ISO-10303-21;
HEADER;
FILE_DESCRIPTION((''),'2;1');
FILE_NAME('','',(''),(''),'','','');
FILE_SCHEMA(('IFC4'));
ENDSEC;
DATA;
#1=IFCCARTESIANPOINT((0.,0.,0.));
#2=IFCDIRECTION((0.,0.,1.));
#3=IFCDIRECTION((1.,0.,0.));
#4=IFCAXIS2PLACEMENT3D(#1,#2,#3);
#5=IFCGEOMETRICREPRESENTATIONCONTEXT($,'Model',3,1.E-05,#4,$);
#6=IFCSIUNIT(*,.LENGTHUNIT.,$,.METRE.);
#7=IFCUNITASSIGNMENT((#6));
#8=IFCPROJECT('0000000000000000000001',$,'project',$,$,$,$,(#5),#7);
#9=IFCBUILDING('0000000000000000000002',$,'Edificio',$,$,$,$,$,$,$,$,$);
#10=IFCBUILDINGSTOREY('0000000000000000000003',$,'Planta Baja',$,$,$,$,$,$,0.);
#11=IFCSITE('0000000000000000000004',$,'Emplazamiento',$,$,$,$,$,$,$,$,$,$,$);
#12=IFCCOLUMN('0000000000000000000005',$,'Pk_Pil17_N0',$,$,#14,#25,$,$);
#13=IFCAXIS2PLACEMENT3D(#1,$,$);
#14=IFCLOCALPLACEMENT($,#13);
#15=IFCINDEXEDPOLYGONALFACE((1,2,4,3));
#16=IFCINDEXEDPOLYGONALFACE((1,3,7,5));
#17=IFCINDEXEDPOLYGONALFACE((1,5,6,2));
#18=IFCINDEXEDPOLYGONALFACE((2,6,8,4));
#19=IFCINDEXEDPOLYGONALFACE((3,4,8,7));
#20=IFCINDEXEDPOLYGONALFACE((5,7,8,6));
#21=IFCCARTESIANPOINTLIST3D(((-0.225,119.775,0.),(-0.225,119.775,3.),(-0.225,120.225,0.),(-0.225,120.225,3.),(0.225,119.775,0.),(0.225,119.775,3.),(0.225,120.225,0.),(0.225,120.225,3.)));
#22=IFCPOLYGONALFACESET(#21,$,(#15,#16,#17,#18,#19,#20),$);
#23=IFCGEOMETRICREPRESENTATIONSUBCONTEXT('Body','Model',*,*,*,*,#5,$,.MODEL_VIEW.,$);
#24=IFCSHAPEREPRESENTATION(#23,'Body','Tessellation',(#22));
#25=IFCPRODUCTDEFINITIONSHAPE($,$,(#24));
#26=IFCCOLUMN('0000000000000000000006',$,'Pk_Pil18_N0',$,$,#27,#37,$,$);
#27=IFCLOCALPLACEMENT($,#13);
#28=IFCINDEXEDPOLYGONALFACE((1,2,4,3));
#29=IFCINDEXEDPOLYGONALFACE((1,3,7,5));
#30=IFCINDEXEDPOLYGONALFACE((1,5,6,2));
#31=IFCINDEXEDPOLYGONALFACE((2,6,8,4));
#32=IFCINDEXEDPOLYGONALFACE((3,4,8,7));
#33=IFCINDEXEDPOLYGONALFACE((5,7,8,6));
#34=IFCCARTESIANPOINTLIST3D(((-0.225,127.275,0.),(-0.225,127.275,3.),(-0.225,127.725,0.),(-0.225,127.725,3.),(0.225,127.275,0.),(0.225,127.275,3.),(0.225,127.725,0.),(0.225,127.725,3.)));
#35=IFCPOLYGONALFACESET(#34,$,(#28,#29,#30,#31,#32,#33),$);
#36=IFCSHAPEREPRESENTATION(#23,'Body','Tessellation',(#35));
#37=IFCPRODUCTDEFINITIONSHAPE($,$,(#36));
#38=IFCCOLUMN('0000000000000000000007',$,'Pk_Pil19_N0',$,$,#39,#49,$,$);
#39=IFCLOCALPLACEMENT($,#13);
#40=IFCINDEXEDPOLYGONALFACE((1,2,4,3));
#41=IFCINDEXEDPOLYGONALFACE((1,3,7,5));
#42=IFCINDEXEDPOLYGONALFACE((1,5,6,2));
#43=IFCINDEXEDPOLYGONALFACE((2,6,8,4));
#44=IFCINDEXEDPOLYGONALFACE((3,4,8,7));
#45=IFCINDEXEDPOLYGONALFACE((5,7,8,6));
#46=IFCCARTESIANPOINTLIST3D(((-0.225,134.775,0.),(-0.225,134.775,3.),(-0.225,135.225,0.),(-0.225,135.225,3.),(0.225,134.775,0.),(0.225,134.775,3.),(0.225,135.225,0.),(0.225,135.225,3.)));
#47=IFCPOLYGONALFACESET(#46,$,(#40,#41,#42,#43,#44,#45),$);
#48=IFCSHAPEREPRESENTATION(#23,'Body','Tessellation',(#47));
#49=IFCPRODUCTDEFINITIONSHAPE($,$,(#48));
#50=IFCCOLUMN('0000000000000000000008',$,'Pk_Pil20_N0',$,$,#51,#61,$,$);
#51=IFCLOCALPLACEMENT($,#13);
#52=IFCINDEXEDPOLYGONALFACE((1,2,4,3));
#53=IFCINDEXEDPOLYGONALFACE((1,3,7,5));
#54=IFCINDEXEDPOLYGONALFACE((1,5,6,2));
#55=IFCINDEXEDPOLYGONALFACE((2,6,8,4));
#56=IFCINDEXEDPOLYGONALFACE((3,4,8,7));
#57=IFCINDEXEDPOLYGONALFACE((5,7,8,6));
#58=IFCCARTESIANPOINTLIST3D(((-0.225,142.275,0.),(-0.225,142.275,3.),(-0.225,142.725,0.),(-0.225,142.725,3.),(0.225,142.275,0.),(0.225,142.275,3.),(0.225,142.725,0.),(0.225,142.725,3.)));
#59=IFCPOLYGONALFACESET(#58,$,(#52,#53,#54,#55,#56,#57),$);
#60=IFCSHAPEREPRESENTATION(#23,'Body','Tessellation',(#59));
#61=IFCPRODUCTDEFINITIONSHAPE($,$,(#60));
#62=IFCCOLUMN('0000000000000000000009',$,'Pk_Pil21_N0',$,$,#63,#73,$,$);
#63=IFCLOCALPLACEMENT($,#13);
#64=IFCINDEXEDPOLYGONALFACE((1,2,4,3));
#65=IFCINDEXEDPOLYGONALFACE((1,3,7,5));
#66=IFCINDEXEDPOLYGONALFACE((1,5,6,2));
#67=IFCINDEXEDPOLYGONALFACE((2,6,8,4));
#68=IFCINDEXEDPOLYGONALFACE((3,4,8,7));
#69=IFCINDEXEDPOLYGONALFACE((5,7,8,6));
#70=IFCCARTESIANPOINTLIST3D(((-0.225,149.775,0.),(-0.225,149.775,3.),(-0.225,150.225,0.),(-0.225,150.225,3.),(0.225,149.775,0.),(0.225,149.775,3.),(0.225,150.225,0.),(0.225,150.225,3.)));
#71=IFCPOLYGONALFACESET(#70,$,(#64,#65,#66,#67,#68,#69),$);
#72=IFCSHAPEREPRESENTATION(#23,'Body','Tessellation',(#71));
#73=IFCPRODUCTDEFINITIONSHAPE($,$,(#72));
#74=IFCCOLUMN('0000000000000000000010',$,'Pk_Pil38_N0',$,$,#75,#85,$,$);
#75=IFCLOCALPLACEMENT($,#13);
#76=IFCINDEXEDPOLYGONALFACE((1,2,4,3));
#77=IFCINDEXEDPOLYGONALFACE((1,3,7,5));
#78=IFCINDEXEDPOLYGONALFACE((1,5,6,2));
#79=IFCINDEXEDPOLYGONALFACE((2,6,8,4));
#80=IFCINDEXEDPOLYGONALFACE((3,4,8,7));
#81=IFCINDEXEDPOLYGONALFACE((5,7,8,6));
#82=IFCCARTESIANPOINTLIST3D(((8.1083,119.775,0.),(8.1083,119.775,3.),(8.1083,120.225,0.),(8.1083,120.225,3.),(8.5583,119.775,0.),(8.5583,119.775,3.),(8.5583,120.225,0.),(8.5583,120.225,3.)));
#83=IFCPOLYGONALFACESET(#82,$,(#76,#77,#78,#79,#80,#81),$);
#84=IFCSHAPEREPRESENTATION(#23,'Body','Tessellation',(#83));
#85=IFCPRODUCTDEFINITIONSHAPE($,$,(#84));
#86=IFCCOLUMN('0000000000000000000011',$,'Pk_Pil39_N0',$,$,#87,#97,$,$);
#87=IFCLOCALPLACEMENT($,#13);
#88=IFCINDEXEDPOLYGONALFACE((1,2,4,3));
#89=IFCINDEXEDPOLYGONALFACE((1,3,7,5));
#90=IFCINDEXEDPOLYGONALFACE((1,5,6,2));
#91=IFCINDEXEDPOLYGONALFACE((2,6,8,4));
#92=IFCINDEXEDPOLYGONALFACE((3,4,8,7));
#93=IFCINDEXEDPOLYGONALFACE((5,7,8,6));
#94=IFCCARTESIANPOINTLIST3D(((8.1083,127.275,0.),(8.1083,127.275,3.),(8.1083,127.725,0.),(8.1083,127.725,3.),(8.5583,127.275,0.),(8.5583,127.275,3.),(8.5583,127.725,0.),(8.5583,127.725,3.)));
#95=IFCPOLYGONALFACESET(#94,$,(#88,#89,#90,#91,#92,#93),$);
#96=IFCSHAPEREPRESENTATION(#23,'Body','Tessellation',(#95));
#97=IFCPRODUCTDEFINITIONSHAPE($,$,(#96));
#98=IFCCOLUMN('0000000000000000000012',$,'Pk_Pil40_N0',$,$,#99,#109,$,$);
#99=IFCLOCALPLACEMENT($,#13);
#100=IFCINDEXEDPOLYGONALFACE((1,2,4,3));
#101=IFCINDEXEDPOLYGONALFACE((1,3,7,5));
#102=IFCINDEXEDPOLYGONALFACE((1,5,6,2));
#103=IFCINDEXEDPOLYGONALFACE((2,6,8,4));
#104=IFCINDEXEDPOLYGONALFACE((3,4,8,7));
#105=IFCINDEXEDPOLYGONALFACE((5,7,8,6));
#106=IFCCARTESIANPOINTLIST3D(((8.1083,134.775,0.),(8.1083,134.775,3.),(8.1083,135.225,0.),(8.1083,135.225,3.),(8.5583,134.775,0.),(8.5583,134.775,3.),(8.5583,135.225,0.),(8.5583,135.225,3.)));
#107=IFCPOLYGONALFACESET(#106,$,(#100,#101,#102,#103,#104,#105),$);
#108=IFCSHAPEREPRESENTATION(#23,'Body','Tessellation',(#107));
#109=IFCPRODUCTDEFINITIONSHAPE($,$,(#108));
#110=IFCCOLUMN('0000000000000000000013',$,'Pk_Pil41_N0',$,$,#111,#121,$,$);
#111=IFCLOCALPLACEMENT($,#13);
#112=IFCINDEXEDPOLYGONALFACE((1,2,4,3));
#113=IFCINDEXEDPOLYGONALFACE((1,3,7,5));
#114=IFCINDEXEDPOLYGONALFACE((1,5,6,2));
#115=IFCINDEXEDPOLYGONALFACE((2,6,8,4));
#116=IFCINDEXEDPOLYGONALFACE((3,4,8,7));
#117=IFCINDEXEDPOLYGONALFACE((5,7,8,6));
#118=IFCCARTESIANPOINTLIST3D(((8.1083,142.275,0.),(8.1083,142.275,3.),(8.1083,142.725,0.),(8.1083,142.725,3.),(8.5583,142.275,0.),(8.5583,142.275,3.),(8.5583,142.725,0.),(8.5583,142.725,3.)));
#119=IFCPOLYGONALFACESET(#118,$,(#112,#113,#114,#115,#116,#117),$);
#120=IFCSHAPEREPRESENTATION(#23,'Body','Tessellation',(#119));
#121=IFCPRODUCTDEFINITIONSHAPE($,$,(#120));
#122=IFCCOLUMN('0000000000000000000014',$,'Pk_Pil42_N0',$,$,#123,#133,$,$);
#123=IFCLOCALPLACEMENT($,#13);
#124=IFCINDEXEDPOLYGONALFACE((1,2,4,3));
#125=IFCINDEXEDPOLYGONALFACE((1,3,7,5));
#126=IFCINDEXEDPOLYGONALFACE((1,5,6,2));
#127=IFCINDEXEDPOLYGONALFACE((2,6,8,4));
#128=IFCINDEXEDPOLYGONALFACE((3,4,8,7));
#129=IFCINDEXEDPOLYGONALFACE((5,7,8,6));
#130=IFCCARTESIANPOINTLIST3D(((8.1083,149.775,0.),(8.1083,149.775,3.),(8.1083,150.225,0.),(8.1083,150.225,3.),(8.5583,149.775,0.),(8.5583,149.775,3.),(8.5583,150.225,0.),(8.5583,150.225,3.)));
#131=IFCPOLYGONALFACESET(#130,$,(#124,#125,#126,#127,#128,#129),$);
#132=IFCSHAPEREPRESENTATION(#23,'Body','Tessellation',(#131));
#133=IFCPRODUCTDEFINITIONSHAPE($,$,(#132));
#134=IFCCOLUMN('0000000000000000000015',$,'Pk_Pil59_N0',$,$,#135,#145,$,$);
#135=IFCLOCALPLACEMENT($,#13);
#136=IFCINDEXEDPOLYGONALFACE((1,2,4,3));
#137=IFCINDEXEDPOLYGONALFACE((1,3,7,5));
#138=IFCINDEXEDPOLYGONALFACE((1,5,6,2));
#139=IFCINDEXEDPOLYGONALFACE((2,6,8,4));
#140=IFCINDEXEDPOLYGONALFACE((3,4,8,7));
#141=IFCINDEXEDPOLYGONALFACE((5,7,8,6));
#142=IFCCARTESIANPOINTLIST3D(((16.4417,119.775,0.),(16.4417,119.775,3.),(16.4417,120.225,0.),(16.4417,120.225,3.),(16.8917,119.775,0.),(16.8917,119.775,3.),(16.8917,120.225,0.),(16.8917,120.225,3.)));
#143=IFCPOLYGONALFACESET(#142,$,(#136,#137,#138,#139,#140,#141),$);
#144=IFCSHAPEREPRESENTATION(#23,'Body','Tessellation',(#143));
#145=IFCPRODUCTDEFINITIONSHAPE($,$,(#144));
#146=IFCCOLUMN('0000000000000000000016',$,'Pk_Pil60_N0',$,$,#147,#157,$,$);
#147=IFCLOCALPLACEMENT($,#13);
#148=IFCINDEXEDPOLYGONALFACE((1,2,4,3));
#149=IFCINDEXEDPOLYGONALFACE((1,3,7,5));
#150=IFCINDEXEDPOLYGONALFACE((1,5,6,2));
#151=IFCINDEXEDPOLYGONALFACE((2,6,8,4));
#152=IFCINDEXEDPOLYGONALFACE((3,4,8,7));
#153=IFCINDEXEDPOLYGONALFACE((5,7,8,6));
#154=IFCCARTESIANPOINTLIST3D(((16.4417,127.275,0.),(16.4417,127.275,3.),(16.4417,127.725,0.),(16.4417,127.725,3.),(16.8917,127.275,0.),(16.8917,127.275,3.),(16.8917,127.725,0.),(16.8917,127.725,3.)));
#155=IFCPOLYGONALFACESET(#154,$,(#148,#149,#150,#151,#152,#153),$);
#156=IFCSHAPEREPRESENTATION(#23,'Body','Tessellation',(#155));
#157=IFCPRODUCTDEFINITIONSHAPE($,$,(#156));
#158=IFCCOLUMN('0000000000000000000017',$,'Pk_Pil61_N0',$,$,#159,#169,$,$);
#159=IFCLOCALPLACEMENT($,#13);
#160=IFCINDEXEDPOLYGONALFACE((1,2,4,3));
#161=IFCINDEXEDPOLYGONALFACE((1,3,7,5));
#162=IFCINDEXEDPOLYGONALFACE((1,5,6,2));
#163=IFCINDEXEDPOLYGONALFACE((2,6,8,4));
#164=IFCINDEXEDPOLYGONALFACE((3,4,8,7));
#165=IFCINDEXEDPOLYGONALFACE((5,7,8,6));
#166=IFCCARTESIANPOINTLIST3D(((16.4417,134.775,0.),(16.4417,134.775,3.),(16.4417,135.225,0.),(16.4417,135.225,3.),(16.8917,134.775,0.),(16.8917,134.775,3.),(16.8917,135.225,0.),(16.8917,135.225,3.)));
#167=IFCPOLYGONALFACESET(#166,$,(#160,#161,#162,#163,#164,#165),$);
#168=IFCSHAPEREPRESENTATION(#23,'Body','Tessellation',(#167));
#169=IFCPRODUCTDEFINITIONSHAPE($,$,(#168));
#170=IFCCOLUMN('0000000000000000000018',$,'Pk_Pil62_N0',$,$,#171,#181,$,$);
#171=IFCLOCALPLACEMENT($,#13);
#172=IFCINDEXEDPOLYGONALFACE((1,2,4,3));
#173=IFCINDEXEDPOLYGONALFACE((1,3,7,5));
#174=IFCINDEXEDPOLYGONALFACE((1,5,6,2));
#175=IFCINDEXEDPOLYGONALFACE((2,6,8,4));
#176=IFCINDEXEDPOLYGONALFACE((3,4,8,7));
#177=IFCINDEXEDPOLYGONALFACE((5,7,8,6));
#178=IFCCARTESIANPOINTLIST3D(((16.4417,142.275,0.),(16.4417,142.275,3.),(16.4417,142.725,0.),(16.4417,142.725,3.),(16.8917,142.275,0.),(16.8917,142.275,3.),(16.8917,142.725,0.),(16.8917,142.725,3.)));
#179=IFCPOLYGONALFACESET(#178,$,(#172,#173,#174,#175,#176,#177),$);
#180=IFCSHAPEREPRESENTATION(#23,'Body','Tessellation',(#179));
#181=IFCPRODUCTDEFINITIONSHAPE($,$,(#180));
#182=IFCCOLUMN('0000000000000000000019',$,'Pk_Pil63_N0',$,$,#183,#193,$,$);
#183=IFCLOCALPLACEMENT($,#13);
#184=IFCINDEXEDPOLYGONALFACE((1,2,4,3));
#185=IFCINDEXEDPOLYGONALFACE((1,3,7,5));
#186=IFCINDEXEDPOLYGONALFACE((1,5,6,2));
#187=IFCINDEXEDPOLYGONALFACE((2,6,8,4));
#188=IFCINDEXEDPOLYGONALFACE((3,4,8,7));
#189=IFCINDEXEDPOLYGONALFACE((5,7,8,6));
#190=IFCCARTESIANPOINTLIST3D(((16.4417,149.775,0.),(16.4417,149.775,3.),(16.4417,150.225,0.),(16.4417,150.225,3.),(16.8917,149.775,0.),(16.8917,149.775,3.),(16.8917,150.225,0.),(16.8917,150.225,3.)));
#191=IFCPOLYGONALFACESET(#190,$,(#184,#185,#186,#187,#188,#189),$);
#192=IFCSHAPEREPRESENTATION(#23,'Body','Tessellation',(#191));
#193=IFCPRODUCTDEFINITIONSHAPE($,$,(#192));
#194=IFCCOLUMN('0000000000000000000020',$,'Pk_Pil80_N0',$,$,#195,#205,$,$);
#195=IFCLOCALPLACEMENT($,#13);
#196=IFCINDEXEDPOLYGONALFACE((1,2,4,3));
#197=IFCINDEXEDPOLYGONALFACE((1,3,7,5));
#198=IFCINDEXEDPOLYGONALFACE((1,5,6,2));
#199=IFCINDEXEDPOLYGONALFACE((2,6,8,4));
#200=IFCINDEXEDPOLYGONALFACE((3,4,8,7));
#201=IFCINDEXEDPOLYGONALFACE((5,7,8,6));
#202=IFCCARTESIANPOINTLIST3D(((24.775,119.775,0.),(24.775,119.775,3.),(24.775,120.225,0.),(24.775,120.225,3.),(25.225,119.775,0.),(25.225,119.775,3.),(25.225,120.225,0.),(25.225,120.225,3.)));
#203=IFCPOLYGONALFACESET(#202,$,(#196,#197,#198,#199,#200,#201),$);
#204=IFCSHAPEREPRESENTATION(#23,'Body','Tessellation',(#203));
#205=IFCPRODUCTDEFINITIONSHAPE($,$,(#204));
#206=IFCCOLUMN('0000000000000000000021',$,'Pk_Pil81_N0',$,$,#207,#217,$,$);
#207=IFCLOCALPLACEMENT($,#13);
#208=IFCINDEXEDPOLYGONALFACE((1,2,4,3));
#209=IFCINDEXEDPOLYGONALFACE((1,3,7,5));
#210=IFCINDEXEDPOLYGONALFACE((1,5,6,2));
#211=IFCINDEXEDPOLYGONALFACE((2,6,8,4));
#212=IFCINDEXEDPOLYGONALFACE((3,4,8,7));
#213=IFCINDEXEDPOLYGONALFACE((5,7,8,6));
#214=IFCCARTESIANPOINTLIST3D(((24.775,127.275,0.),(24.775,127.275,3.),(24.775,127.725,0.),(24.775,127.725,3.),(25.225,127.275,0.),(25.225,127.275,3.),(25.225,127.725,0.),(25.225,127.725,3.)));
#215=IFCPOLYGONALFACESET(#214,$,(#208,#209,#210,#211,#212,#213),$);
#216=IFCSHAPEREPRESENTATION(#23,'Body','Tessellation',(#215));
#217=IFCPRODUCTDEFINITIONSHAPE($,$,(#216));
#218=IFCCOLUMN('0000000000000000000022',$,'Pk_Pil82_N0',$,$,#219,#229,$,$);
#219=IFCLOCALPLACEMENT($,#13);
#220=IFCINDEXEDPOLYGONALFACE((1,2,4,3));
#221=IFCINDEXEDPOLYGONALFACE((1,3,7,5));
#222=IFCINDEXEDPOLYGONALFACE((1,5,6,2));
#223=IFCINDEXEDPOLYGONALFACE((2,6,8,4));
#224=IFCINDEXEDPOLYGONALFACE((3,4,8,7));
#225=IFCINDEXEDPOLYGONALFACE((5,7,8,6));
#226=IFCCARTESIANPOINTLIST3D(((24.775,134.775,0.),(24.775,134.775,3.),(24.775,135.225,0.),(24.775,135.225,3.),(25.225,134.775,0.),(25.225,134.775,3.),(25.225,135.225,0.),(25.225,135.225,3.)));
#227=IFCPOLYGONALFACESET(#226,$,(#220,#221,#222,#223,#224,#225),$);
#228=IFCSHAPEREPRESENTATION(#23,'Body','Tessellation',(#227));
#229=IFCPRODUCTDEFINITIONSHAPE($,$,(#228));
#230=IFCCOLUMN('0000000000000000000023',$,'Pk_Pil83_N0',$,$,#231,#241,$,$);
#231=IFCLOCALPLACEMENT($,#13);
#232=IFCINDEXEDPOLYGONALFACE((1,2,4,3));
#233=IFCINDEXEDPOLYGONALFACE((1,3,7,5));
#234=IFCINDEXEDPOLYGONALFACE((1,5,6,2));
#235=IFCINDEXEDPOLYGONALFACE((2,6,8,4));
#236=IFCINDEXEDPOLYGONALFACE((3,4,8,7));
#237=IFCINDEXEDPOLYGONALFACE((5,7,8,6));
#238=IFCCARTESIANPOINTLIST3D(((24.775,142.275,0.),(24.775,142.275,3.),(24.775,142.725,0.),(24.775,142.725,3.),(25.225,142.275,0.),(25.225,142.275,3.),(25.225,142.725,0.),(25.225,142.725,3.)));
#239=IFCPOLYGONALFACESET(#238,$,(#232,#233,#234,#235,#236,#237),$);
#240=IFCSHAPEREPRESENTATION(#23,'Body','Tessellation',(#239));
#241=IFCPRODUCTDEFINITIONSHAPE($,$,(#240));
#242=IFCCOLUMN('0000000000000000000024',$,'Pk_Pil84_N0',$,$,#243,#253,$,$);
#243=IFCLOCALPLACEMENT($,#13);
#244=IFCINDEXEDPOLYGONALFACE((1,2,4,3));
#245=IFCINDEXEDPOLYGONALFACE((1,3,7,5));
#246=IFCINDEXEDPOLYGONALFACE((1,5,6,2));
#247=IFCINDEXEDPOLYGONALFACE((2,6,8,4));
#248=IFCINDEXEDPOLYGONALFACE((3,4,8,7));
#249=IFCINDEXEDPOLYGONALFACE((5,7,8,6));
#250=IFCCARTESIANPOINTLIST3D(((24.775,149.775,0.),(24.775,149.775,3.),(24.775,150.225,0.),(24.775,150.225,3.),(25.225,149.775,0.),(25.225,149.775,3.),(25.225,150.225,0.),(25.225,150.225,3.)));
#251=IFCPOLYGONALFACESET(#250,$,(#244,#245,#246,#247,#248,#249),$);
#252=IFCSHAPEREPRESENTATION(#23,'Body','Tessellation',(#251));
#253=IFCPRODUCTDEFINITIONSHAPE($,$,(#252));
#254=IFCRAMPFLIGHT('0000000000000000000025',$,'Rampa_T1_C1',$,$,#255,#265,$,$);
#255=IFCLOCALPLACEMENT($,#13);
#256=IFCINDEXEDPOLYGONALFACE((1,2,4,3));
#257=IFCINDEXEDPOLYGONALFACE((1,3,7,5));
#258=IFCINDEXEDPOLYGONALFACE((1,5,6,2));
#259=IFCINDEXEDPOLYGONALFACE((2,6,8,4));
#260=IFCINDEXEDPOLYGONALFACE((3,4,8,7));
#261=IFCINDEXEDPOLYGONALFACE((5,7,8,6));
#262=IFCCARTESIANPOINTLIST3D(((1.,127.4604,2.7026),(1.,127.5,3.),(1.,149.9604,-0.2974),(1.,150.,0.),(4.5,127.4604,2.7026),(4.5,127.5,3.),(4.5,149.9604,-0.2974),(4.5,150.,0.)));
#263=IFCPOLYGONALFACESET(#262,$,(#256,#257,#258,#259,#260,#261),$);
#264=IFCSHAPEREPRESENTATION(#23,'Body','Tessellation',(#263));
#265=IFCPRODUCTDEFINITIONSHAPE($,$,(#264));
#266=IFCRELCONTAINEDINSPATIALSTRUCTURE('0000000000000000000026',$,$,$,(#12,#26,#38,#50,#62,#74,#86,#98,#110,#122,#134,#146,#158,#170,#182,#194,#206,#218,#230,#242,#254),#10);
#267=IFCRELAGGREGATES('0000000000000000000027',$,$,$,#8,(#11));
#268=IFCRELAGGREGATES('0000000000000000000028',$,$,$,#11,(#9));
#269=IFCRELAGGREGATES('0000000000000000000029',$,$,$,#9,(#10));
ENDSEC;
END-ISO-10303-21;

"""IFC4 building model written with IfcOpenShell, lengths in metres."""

from ifc_helpers import new_model, si_unit, frame, origin_with_axes, origin_2d, place, context, subcontext, project, spatial, rectangle, extrude, element, save


model = new_model("IFC4")

# Units and contexts
model_context = context("Model", 3, precision=1e-05, world=origin_with_axes())
body_context = subcontext(model_context, "Body", "Model", "MODEL_VIEW")
ifc_project = project(units=[si_unit("LENGTHUNIT", "METRE")], contexts=[model_context])

# Site, building, storey
site = spatial("IfcSite", under=ifc_project, Name="Emplazamiento")
building = spatial("IfcBuilding", under=site, Name="Edificio")
storey = spatial("IfcBuildingStorey", under=building, Name="Planta Baja", Elevation=0.0)

# Columns
for number, where, z_axis, x_axis, name in (
    (1, (0.0, 120.0, 0.0), (0.0, 0.0, 1.0), (1.0, 0.0, 0.0), "Pk_Pil17_N0"),
    (2, (0.0, 127.5, 0.0), (0.0, 0.0, 1.0), (1.0, 0.0, 0.0), "Pk_Pil18_N0"),
    (3, (0.0, 135.0, 0.0), (0.0, 0.0, 1.0), (1.0, 0.0, 0.0), "Pk_Pil19_N0"),
    (4, (0.0, 142.5, 0.0), (0.0, 0.0, 1.0), (1.0, 0.0, 0.0), "Pk_Pil20_N0"),
    (5, (0.0, 150.0, 0.0), (0.0, 0.0, 1.0), (1.0, 0.0, 0.0), "Pk_Pil21_N0"),
    (6, (8.3333, 120.0, 0.0), (0.0, 0.0, 1.0), (1.0, 0.0, 0.0), "Pk_Pil38_N0"),
    (7, (8.3333, 127.5, 0.0), (0.0, 0.0, 1.0), (1.0, 0.0, 0.0), "Pk_Pil39_N0"),
    (8, (8.3333, 135.0, 0.0), (0.0, 0.0, 1.0), (1.0, 0.0, 0.0), "Pk_Pil40_N0"),
    (9, (8.3333, 142.5, 0.0), (0.0, 0.0, 1.0), (1.0, 0.0, 0.0), "Pk_Pil41_N0"),
    (10, (8.3333, 150.0, 0.0), (0.0, 0.0, 1.0), (1.0, 0.0, 0.0), "Pk_Pil42_N0"),
    (11, (16.6667, 120.0, 0.0), (0.0, 0.0, 1.0), (1.0, 0.0, 0.0), "Pk_Pil59_N0"),
    (12, (16.6667, 127.5, 0.0), (0.0, 0.0, 1.0), (1.0, 0.0, 0.0), "Pk_Pil60_N0"),
    (13, (16.6667, 135.0, 0.0), (0.0, 0.0, 1.0), (1.0, 0.0, 0.0), "Pk_Pil61_N0"),
    (14, (16.6667, 142.5, 0.0), (0.0, 0.0, 1.0), (1.0, 0.0, 0.0), "Pk_Pil62_N0"),
    (15, (16.6667, 150.0, 0.0), (0.0, 0.0, 1.0), (1.0, 0.0, 0.0), "Pk_Pil63_N0"),
    (16, (25.0, 120.0, 0.0), (0.0, 0.0, 1.0), (1.0, 0.0, 0.0), "Pk_Pil80_N0"),
    (17, (25.0, 127.5, 0.0), (0.0, 0.0, 1.0), (1.0, 0.0, 0.0), "Pk_Pil81_N0"),
    (18, (25.0, 135.0, 0.0), (0.0, 0.0, 1.0), (1.0, 0.0, 0.0), "Pk_Pil82_N0"),
    (19, (25.0, 142.5, 0.0), (0.0, 0.0, 1.0), (1.0, 0.0, 0.0), "Pk_Pil83_N0"),
    (20, (25.0, 150.0, 0.0), (0.0, 0.0, 1.0), (1.0, 0.0, 0.0), "Pk_Pil84_N0"),
):
    element("IfcColumn", number, at=place(None, frame(where, z_axis=z_axis, x_axis=x_axis)), inside=storey, Name=name, context=body_context, shape_type="SweptSolid", body=[
        extrude(rectangle(XDim=0.45, YDim=0.45, at=origin_2d()), origin_with_axes(), (0.0, 0.0, 1.0), 3.0),
    ])

# Ramp flight
for number, where, z_axis, x_axis, name in (
    (21, (2.75, 138.7104, 1.2026), (0.0, 0.132164, 0.991228), (0.0, -0.991228, 0.132164), "Rampa_T1_C1"),
):
    element("IfcRampFlight", number, at=place(None, frame(where, z_axis=z_axis, x_axis=x_axis)), inside=storey, Name=name, context=body_context, shape_type="SweptSolid", body=[
        extrude(rectangle(XDim=22.6991, YDim=3.5, at=origin_2d()), origin_with_axes(), (0.0, 0.0, 1.0), 0.3),
    ])

save(model, "model.ifc")
